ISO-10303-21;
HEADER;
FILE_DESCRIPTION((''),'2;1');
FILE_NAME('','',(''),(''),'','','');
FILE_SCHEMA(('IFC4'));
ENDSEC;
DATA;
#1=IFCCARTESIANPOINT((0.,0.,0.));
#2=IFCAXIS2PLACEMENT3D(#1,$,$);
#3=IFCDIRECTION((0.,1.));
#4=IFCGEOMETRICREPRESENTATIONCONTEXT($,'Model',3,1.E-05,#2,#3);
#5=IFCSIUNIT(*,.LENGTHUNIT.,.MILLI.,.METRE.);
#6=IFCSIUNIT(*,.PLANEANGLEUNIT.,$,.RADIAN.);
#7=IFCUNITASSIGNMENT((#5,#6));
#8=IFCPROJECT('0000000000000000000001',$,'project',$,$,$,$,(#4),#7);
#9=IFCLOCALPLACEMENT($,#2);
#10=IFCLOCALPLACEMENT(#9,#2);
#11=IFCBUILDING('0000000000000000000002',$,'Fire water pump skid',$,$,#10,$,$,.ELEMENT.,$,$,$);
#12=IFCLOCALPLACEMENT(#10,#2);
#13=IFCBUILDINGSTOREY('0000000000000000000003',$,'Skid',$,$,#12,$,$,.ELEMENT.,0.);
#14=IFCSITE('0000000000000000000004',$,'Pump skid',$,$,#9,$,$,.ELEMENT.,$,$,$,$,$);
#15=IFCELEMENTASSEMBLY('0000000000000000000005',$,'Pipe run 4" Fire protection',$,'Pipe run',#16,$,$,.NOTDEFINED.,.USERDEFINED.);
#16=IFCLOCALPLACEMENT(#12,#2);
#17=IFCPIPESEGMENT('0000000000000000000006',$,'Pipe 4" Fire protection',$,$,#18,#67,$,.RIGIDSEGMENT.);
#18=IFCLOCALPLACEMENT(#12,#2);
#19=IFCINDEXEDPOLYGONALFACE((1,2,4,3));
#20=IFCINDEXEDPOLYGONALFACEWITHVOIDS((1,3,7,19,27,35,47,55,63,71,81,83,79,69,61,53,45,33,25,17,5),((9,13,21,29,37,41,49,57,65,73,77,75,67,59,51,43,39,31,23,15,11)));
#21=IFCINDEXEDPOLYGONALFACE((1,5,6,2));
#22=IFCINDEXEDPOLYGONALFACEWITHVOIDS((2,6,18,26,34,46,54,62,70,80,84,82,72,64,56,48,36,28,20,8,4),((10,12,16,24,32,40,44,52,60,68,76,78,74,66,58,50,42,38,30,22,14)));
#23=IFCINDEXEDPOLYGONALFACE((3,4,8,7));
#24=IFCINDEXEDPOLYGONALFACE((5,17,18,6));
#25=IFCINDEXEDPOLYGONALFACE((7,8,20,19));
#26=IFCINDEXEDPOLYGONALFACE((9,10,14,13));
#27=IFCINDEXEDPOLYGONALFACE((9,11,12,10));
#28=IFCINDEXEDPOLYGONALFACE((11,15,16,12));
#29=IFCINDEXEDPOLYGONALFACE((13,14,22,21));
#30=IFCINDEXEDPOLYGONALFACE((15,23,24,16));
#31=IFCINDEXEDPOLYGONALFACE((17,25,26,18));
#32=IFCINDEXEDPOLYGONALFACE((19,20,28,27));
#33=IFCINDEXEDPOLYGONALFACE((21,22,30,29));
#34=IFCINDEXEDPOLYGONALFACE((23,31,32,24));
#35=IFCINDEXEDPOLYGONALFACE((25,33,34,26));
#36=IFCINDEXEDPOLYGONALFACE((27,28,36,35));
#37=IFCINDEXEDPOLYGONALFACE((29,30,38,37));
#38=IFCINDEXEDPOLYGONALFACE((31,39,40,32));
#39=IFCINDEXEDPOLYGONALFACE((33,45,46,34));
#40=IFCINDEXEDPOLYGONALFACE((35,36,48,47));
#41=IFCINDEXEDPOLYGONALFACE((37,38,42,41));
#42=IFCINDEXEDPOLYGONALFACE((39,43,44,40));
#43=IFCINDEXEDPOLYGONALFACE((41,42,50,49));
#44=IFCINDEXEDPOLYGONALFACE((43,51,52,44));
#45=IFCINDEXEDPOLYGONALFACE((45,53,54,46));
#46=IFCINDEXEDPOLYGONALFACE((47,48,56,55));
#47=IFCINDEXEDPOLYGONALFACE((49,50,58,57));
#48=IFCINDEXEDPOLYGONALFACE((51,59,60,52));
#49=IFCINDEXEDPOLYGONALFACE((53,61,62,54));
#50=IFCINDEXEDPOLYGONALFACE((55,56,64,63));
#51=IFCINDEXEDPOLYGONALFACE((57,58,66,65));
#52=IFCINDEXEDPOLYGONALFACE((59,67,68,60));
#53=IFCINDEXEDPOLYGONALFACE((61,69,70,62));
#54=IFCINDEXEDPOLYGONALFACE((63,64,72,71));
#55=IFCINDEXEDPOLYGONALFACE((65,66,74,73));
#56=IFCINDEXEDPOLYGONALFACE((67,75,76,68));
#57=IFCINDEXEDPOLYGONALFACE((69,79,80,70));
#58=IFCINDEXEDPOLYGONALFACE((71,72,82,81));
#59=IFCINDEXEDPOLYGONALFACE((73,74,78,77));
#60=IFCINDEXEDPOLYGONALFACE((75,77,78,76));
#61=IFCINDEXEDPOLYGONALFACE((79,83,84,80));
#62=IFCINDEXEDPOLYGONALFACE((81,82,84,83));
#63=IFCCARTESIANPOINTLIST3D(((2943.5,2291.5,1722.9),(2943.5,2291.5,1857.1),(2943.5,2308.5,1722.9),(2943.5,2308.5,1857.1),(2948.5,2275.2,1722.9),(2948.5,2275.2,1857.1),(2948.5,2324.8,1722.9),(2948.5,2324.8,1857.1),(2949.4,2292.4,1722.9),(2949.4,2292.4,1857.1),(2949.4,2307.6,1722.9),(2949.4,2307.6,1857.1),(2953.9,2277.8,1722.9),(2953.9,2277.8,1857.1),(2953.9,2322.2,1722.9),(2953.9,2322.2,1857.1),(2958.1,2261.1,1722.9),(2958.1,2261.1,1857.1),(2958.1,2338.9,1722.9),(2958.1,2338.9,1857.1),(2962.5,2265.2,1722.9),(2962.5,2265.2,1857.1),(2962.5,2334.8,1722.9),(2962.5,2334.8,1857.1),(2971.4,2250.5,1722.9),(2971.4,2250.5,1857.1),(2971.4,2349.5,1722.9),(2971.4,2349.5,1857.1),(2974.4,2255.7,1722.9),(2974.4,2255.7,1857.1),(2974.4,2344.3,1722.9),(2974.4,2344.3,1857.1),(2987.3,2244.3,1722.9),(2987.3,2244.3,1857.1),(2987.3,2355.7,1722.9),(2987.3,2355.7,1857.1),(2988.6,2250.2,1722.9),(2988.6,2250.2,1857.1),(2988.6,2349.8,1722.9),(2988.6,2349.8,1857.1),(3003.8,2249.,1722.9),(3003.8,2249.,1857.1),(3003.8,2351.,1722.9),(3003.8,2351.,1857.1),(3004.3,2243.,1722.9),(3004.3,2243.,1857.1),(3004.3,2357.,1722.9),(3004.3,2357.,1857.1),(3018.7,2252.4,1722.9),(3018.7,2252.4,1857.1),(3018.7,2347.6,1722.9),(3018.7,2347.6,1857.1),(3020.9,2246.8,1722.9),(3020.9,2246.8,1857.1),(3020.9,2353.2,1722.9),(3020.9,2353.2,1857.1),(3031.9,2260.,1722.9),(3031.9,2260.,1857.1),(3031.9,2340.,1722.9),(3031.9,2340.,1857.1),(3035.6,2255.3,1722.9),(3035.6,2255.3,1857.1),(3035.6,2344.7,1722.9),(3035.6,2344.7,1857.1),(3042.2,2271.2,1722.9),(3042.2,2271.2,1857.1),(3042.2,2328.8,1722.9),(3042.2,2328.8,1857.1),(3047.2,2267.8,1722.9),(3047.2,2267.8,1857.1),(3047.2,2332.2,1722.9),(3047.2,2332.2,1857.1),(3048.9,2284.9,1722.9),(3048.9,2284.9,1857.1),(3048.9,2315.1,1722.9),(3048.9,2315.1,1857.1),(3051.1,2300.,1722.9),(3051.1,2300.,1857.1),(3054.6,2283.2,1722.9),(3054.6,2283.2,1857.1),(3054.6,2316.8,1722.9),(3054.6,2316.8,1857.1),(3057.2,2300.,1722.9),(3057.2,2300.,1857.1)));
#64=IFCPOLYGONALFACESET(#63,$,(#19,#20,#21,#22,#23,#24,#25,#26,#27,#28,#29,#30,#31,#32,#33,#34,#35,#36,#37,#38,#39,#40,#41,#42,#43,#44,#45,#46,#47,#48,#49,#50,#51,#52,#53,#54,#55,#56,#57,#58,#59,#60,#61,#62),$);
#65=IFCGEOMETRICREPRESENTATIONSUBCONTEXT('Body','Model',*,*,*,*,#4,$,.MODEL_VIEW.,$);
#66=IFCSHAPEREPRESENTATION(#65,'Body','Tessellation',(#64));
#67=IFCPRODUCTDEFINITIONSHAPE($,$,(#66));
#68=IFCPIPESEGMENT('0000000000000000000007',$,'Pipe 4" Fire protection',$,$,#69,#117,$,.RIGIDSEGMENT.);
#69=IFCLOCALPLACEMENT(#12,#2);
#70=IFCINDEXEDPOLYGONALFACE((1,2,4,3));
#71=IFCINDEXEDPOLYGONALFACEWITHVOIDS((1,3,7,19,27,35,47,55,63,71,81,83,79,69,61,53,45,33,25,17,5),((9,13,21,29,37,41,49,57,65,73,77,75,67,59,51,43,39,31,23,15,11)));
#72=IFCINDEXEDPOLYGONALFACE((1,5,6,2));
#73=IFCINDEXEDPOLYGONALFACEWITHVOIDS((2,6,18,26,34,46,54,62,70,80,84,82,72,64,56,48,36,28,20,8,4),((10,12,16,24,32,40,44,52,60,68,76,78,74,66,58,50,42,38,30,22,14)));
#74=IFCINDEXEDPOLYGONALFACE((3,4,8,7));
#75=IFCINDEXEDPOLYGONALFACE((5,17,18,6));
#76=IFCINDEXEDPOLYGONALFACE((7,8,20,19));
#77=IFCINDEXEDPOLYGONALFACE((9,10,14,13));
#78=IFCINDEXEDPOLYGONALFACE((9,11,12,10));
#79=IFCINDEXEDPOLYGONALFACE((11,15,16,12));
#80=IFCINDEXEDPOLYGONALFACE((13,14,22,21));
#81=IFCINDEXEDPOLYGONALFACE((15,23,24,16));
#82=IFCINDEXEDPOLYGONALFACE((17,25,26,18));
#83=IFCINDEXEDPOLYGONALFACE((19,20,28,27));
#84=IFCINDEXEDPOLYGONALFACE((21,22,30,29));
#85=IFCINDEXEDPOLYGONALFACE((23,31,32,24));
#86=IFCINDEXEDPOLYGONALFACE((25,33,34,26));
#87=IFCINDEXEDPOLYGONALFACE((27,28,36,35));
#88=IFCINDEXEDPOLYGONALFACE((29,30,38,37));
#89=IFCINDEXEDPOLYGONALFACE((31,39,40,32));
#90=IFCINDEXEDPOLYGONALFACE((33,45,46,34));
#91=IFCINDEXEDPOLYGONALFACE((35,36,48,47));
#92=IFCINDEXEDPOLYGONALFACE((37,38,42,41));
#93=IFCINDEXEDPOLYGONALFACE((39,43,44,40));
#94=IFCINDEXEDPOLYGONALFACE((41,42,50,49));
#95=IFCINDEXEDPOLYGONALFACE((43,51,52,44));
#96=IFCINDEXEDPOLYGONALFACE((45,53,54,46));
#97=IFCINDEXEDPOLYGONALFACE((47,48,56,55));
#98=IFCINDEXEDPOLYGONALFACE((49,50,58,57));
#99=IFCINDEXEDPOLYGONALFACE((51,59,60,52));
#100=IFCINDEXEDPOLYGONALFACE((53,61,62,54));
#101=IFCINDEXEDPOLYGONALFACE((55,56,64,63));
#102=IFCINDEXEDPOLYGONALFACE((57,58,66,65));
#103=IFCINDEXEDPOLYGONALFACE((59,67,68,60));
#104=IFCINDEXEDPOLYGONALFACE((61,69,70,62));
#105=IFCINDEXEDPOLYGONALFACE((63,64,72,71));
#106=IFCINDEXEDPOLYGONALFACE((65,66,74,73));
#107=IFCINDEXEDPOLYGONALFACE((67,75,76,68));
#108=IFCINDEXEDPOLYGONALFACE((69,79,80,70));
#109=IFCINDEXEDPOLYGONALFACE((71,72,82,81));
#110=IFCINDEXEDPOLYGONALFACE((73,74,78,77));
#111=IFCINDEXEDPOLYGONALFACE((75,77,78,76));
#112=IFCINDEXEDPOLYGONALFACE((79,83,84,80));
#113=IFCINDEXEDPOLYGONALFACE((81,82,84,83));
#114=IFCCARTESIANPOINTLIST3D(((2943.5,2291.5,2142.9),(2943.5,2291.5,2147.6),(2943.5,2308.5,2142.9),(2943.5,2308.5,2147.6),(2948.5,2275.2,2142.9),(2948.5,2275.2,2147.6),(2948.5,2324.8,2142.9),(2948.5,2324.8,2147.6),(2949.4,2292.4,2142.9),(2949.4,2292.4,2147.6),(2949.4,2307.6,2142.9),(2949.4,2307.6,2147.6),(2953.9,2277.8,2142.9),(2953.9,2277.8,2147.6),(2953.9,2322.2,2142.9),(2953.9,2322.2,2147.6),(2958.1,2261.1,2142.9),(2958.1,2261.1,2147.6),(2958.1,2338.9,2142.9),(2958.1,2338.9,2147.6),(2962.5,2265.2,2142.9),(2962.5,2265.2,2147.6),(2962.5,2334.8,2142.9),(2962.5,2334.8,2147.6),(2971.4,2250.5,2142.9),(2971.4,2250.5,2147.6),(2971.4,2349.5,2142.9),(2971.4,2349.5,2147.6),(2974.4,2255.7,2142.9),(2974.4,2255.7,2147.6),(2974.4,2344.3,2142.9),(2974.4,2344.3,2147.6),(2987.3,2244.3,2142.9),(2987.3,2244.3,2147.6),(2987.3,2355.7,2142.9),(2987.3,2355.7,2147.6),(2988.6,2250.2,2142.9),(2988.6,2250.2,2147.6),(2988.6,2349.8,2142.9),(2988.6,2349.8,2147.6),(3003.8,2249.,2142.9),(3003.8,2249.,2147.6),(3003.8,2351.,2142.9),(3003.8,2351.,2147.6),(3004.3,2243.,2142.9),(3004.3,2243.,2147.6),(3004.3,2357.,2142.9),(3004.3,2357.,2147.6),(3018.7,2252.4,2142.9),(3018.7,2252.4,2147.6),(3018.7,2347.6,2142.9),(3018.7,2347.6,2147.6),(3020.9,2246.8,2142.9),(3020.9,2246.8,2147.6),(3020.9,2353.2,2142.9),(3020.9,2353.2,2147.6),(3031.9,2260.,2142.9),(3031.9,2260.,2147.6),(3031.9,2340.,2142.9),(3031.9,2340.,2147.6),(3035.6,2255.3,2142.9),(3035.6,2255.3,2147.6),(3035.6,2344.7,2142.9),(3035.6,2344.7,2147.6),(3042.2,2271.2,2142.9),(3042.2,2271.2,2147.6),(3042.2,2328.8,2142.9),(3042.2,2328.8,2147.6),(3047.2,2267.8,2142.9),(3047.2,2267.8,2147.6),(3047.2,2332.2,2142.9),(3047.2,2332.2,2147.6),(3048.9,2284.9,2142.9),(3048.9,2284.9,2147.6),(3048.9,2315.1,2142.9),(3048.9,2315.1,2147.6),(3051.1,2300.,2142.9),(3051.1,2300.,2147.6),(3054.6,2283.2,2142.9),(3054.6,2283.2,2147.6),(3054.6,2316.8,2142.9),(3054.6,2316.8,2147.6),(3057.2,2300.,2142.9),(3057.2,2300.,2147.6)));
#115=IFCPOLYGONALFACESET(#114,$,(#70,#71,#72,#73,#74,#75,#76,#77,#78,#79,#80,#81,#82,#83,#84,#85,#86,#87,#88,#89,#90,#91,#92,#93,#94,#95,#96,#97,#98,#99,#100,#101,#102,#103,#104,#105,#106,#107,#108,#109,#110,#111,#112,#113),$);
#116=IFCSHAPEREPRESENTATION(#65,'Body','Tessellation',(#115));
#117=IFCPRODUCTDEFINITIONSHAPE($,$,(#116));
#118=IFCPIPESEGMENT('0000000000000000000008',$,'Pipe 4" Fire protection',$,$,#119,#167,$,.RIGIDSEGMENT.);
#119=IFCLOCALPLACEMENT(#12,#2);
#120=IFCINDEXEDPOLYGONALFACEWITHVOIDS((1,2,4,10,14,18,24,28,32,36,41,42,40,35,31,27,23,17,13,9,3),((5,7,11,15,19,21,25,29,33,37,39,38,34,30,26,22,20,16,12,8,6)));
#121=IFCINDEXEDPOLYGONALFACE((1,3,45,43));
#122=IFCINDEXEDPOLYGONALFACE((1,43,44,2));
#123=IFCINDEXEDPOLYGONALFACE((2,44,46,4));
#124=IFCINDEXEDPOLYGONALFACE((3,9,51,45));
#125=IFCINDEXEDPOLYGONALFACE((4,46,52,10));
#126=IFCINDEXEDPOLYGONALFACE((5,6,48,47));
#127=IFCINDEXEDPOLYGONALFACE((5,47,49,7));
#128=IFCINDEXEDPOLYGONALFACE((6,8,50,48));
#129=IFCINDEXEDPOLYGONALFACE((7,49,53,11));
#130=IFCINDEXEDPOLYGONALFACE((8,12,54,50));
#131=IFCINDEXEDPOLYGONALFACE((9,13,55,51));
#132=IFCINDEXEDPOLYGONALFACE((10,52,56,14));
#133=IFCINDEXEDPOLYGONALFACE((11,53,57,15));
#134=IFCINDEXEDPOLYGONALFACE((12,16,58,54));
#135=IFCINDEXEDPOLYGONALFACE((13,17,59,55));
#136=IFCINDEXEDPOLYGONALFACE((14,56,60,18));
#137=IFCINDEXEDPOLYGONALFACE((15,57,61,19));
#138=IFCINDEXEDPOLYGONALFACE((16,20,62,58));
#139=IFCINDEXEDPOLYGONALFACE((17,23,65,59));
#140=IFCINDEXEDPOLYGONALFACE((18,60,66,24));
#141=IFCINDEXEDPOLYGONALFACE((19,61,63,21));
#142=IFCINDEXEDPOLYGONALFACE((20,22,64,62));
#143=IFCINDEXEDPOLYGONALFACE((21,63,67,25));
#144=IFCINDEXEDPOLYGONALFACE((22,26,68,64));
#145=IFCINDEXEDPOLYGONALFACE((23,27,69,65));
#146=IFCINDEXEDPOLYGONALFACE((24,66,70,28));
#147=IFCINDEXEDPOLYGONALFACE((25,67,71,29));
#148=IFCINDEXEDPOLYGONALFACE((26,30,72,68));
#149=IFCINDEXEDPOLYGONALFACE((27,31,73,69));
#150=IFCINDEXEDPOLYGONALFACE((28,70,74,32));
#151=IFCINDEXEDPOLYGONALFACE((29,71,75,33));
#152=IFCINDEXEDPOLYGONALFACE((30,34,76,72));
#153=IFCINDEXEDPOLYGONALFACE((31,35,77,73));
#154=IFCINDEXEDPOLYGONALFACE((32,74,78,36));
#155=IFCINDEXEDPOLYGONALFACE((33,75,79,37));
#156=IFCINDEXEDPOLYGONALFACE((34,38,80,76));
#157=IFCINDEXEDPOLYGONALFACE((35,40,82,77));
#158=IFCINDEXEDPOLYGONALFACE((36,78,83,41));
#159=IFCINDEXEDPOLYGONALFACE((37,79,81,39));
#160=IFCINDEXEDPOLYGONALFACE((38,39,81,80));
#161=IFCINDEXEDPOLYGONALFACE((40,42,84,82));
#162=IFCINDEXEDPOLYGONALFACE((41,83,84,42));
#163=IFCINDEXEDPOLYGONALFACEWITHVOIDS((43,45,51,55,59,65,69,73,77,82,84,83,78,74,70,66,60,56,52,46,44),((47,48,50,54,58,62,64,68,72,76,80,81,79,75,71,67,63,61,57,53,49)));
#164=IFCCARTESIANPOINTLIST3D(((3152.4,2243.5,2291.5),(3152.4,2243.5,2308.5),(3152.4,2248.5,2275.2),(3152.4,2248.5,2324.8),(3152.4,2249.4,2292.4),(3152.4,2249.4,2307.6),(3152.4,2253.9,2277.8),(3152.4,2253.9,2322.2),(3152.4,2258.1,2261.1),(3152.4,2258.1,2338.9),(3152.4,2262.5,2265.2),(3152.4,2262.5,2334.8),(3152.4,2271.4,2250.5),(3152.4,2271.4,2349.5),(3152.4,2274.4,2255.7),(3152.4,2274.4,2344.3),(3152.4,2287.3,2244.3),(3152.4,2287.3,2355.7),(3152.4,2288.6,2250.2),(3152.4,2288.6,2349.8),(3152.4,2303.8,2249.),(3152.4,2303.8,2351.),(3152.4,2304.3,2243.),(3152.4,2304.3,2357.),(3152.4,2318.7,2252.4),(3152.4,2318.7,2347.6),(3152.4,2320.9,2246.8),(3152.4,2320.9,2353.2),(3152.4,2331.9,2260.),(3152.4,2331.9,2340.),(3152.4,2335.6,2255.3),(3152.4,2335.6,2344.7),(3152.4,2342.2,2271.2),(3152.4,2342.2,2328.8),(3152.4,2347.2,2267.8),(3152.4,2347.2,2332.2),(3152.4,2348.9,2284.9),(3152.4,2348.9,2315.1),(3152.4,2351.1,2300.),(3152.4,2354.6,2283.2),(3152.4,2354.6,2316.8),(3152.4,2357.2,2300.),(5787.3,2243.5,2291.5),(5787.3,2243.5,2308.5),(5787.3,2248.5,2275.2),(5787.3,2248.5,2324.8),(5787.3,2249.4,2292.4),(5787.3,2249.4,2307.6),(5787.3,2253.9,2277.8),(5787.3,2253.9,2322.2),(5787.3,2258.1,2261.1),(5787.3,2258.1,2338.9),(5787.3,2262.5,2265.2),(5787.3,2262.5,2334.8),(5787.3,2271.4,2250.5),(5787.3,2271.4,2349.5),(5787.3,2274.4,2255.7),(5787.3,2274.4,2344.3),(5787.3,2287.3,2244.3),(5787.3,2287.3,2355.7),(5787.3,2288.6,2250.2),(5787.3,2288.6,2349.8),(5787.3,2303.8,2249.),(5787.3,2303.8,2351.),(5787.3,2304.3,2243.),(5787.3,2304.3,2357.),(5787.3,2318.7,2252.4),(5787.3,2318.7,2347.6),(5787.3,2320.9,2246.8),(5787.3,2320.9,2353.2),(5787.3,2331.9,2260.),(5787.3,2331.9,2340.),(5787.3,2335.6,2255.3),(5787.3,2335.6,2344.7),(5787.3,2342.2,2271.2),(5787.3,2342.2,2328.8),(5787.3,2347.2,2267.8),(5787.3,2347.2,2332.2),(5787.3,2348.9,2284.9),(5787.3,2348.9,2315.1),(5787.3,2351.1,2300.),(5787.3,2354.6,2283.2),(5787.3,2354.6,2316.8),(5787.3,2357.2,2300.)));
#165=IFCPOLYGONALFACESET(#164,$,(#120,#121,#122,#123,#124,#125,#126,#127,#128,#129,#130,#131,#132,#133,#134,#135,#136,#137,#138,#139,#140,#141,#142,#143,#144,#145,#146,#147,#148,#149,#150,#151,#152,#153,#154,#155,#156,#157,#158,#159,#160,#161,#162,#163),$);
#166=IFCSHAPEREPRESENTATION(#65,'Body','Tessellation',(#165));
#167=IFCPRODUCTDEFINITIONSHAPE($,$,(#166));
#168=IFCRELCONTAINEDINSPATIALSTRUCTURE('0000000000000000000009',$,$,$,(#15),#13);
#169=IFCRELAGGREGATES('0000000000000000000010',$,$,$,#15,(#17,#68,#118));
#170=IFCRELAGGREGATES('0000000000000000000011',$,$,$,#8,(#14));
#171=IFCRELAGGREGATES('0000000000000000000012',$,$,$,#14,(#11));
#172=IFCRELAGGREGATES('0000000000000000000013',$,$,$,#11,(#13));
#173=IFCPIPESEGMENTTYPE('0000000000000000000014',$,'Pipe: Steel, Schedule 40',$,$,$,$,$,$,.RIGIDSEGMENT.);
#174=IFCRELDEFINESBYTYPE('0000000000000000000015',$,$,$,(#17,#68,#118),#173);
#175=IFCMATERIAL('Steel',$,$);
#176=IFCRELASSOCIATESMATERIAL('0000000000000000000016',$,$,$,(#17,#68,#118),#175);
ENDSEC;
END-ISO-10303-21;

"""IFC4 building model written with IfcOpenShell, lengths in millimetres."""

from ifc_helpers import new_model, si_unit, direction, frame, origin, origin_with_axes, origin_2d, place, context, subcontext, project, spatial, hollow_circle, extrude, material, type_object, element, aggregate, save


model = new_model("IFC4")

# Units and contexts
model_context = context("Model", 3, precision=1e-05, world=origin(), true_north=direction((0.0, 1.0)))
body_context = subcontext(model_context, "Body", "Model", "MODEL_VIEW")
ifc_project = project(units=[si_unit("LENGTHUNIT", "METRE", prefix="MILLI"), si_unit("PLANEANGLEUNIT", "RADIAN")], contexts=[model_context])

# Site, building, storey
site_placement = place(None, origin())
site = spatial("IfcSite", under=ifc_project, at=site_placement, Name="Pump skid", CompositionType="ELEMENT")
building_placement = place(site_placement, origin())
building = spatial("IfcBuilding", under=site, at=building_placement, Name="Fire water pump skid", CompositionType="ELEMENT")
storey_placement = place(building_placement, origin())
storey = spatial("IfcBuildingStorey", under=building, at=storey_placement, Name="Skid", CompositionType="ELEMENT", Elevation=0.0)

# Element assembly, pipe segments
ifc_material = material(Name="Steel")
pipe_segment_type = type_object("IfcPipeSegmentType", Name="Pipe: Steel, Schedule 40", PredefinedType="RIGIDSEGMENT")
assembly_1_placement = place(storey_placement, origin_with_axes())
assembly_1 = element("IfcElementAssembly", 1, at=assembly_1_placement, inside=storey, Name="Pipe run 4\" Fire protection", ObjectType="Pipe run", AssemblyPlace="NOTDEFINED", PredefinedType="USERDEFINED")
pipe_segment_1_placement = place(storey_placement, origin_with_axes())
pipe_segment_1 = element("IfcPipeSegment", 2, at=pipe_segment_1_placement, type_object=pipe_segment_type, material=ifc_material, Name="Pipe 4\" Fire protection", PredefinedType="RIGIDSEGMENT", context=body_context, shape_type="SweptSolid", body=[
    extrude(hollow_circle(Radius=57.1, WallThickness=6.0, at=origin_2d()), frame((3000.0, 2300.0, 1722.9), z_axis=(0.0, 0.0, 1.0), x_axis=(1.0, 0.0, 0.0)), (0.0, 0.0, 1.0), 134.2),
])
pipe_segment_2_placement = place(storey_placement, origin_with_axes())
pipe_segment_2 = element("IfcPipeSegment", 3, at=pipe_segment_2_placement, type_object=pipe_segment_type, material=ifc_material, Name="Pipe 4\" Fire protection", PredefinedType="RIGIDSEGMENT", context=body_context, shape_type="SweptSolid", body=[
    extrude(hollow_circle(Radius=57.1, WallThickness=6.0, at=origin_2d()), frame((3000.0, 2300.0, 2142.9), z_axis=(0.0, 0.0, 1.0), x_axis=(1.0, 0.0, 0.0)), (0.0, 0.0, 1.0), 4.7),
])
pipe_segment_3_placement = place(storey_placement, origin_with_axes())
pipe_segment_3 = element("IfcPipeSegment", 4, at=pipe_segment_3_placement, type_object=pipe_segment_type, material=ifc_material, Name="Pipe 4\" Fire protection", PredefinedType="RIGIDSEGMENT", context=body_context, shape_type="SweptSolid", body=[
    extrude(hollow_circle(Radius=57.1, WallThickness=6.0, at=origin_2d()), frame((3152.4, 2300.0, 2300.0), z_axis=(1.0, 0.0, 0.0), x_axis=(0.0, 1.0, 0.0)), (0.0, 0.0, 1.0), 2634.9),
])

aggregate(assembly_1, [pipe_segment_1, pipe_segment_2, pipe_segment_3])

save(model, "model.ifc")
